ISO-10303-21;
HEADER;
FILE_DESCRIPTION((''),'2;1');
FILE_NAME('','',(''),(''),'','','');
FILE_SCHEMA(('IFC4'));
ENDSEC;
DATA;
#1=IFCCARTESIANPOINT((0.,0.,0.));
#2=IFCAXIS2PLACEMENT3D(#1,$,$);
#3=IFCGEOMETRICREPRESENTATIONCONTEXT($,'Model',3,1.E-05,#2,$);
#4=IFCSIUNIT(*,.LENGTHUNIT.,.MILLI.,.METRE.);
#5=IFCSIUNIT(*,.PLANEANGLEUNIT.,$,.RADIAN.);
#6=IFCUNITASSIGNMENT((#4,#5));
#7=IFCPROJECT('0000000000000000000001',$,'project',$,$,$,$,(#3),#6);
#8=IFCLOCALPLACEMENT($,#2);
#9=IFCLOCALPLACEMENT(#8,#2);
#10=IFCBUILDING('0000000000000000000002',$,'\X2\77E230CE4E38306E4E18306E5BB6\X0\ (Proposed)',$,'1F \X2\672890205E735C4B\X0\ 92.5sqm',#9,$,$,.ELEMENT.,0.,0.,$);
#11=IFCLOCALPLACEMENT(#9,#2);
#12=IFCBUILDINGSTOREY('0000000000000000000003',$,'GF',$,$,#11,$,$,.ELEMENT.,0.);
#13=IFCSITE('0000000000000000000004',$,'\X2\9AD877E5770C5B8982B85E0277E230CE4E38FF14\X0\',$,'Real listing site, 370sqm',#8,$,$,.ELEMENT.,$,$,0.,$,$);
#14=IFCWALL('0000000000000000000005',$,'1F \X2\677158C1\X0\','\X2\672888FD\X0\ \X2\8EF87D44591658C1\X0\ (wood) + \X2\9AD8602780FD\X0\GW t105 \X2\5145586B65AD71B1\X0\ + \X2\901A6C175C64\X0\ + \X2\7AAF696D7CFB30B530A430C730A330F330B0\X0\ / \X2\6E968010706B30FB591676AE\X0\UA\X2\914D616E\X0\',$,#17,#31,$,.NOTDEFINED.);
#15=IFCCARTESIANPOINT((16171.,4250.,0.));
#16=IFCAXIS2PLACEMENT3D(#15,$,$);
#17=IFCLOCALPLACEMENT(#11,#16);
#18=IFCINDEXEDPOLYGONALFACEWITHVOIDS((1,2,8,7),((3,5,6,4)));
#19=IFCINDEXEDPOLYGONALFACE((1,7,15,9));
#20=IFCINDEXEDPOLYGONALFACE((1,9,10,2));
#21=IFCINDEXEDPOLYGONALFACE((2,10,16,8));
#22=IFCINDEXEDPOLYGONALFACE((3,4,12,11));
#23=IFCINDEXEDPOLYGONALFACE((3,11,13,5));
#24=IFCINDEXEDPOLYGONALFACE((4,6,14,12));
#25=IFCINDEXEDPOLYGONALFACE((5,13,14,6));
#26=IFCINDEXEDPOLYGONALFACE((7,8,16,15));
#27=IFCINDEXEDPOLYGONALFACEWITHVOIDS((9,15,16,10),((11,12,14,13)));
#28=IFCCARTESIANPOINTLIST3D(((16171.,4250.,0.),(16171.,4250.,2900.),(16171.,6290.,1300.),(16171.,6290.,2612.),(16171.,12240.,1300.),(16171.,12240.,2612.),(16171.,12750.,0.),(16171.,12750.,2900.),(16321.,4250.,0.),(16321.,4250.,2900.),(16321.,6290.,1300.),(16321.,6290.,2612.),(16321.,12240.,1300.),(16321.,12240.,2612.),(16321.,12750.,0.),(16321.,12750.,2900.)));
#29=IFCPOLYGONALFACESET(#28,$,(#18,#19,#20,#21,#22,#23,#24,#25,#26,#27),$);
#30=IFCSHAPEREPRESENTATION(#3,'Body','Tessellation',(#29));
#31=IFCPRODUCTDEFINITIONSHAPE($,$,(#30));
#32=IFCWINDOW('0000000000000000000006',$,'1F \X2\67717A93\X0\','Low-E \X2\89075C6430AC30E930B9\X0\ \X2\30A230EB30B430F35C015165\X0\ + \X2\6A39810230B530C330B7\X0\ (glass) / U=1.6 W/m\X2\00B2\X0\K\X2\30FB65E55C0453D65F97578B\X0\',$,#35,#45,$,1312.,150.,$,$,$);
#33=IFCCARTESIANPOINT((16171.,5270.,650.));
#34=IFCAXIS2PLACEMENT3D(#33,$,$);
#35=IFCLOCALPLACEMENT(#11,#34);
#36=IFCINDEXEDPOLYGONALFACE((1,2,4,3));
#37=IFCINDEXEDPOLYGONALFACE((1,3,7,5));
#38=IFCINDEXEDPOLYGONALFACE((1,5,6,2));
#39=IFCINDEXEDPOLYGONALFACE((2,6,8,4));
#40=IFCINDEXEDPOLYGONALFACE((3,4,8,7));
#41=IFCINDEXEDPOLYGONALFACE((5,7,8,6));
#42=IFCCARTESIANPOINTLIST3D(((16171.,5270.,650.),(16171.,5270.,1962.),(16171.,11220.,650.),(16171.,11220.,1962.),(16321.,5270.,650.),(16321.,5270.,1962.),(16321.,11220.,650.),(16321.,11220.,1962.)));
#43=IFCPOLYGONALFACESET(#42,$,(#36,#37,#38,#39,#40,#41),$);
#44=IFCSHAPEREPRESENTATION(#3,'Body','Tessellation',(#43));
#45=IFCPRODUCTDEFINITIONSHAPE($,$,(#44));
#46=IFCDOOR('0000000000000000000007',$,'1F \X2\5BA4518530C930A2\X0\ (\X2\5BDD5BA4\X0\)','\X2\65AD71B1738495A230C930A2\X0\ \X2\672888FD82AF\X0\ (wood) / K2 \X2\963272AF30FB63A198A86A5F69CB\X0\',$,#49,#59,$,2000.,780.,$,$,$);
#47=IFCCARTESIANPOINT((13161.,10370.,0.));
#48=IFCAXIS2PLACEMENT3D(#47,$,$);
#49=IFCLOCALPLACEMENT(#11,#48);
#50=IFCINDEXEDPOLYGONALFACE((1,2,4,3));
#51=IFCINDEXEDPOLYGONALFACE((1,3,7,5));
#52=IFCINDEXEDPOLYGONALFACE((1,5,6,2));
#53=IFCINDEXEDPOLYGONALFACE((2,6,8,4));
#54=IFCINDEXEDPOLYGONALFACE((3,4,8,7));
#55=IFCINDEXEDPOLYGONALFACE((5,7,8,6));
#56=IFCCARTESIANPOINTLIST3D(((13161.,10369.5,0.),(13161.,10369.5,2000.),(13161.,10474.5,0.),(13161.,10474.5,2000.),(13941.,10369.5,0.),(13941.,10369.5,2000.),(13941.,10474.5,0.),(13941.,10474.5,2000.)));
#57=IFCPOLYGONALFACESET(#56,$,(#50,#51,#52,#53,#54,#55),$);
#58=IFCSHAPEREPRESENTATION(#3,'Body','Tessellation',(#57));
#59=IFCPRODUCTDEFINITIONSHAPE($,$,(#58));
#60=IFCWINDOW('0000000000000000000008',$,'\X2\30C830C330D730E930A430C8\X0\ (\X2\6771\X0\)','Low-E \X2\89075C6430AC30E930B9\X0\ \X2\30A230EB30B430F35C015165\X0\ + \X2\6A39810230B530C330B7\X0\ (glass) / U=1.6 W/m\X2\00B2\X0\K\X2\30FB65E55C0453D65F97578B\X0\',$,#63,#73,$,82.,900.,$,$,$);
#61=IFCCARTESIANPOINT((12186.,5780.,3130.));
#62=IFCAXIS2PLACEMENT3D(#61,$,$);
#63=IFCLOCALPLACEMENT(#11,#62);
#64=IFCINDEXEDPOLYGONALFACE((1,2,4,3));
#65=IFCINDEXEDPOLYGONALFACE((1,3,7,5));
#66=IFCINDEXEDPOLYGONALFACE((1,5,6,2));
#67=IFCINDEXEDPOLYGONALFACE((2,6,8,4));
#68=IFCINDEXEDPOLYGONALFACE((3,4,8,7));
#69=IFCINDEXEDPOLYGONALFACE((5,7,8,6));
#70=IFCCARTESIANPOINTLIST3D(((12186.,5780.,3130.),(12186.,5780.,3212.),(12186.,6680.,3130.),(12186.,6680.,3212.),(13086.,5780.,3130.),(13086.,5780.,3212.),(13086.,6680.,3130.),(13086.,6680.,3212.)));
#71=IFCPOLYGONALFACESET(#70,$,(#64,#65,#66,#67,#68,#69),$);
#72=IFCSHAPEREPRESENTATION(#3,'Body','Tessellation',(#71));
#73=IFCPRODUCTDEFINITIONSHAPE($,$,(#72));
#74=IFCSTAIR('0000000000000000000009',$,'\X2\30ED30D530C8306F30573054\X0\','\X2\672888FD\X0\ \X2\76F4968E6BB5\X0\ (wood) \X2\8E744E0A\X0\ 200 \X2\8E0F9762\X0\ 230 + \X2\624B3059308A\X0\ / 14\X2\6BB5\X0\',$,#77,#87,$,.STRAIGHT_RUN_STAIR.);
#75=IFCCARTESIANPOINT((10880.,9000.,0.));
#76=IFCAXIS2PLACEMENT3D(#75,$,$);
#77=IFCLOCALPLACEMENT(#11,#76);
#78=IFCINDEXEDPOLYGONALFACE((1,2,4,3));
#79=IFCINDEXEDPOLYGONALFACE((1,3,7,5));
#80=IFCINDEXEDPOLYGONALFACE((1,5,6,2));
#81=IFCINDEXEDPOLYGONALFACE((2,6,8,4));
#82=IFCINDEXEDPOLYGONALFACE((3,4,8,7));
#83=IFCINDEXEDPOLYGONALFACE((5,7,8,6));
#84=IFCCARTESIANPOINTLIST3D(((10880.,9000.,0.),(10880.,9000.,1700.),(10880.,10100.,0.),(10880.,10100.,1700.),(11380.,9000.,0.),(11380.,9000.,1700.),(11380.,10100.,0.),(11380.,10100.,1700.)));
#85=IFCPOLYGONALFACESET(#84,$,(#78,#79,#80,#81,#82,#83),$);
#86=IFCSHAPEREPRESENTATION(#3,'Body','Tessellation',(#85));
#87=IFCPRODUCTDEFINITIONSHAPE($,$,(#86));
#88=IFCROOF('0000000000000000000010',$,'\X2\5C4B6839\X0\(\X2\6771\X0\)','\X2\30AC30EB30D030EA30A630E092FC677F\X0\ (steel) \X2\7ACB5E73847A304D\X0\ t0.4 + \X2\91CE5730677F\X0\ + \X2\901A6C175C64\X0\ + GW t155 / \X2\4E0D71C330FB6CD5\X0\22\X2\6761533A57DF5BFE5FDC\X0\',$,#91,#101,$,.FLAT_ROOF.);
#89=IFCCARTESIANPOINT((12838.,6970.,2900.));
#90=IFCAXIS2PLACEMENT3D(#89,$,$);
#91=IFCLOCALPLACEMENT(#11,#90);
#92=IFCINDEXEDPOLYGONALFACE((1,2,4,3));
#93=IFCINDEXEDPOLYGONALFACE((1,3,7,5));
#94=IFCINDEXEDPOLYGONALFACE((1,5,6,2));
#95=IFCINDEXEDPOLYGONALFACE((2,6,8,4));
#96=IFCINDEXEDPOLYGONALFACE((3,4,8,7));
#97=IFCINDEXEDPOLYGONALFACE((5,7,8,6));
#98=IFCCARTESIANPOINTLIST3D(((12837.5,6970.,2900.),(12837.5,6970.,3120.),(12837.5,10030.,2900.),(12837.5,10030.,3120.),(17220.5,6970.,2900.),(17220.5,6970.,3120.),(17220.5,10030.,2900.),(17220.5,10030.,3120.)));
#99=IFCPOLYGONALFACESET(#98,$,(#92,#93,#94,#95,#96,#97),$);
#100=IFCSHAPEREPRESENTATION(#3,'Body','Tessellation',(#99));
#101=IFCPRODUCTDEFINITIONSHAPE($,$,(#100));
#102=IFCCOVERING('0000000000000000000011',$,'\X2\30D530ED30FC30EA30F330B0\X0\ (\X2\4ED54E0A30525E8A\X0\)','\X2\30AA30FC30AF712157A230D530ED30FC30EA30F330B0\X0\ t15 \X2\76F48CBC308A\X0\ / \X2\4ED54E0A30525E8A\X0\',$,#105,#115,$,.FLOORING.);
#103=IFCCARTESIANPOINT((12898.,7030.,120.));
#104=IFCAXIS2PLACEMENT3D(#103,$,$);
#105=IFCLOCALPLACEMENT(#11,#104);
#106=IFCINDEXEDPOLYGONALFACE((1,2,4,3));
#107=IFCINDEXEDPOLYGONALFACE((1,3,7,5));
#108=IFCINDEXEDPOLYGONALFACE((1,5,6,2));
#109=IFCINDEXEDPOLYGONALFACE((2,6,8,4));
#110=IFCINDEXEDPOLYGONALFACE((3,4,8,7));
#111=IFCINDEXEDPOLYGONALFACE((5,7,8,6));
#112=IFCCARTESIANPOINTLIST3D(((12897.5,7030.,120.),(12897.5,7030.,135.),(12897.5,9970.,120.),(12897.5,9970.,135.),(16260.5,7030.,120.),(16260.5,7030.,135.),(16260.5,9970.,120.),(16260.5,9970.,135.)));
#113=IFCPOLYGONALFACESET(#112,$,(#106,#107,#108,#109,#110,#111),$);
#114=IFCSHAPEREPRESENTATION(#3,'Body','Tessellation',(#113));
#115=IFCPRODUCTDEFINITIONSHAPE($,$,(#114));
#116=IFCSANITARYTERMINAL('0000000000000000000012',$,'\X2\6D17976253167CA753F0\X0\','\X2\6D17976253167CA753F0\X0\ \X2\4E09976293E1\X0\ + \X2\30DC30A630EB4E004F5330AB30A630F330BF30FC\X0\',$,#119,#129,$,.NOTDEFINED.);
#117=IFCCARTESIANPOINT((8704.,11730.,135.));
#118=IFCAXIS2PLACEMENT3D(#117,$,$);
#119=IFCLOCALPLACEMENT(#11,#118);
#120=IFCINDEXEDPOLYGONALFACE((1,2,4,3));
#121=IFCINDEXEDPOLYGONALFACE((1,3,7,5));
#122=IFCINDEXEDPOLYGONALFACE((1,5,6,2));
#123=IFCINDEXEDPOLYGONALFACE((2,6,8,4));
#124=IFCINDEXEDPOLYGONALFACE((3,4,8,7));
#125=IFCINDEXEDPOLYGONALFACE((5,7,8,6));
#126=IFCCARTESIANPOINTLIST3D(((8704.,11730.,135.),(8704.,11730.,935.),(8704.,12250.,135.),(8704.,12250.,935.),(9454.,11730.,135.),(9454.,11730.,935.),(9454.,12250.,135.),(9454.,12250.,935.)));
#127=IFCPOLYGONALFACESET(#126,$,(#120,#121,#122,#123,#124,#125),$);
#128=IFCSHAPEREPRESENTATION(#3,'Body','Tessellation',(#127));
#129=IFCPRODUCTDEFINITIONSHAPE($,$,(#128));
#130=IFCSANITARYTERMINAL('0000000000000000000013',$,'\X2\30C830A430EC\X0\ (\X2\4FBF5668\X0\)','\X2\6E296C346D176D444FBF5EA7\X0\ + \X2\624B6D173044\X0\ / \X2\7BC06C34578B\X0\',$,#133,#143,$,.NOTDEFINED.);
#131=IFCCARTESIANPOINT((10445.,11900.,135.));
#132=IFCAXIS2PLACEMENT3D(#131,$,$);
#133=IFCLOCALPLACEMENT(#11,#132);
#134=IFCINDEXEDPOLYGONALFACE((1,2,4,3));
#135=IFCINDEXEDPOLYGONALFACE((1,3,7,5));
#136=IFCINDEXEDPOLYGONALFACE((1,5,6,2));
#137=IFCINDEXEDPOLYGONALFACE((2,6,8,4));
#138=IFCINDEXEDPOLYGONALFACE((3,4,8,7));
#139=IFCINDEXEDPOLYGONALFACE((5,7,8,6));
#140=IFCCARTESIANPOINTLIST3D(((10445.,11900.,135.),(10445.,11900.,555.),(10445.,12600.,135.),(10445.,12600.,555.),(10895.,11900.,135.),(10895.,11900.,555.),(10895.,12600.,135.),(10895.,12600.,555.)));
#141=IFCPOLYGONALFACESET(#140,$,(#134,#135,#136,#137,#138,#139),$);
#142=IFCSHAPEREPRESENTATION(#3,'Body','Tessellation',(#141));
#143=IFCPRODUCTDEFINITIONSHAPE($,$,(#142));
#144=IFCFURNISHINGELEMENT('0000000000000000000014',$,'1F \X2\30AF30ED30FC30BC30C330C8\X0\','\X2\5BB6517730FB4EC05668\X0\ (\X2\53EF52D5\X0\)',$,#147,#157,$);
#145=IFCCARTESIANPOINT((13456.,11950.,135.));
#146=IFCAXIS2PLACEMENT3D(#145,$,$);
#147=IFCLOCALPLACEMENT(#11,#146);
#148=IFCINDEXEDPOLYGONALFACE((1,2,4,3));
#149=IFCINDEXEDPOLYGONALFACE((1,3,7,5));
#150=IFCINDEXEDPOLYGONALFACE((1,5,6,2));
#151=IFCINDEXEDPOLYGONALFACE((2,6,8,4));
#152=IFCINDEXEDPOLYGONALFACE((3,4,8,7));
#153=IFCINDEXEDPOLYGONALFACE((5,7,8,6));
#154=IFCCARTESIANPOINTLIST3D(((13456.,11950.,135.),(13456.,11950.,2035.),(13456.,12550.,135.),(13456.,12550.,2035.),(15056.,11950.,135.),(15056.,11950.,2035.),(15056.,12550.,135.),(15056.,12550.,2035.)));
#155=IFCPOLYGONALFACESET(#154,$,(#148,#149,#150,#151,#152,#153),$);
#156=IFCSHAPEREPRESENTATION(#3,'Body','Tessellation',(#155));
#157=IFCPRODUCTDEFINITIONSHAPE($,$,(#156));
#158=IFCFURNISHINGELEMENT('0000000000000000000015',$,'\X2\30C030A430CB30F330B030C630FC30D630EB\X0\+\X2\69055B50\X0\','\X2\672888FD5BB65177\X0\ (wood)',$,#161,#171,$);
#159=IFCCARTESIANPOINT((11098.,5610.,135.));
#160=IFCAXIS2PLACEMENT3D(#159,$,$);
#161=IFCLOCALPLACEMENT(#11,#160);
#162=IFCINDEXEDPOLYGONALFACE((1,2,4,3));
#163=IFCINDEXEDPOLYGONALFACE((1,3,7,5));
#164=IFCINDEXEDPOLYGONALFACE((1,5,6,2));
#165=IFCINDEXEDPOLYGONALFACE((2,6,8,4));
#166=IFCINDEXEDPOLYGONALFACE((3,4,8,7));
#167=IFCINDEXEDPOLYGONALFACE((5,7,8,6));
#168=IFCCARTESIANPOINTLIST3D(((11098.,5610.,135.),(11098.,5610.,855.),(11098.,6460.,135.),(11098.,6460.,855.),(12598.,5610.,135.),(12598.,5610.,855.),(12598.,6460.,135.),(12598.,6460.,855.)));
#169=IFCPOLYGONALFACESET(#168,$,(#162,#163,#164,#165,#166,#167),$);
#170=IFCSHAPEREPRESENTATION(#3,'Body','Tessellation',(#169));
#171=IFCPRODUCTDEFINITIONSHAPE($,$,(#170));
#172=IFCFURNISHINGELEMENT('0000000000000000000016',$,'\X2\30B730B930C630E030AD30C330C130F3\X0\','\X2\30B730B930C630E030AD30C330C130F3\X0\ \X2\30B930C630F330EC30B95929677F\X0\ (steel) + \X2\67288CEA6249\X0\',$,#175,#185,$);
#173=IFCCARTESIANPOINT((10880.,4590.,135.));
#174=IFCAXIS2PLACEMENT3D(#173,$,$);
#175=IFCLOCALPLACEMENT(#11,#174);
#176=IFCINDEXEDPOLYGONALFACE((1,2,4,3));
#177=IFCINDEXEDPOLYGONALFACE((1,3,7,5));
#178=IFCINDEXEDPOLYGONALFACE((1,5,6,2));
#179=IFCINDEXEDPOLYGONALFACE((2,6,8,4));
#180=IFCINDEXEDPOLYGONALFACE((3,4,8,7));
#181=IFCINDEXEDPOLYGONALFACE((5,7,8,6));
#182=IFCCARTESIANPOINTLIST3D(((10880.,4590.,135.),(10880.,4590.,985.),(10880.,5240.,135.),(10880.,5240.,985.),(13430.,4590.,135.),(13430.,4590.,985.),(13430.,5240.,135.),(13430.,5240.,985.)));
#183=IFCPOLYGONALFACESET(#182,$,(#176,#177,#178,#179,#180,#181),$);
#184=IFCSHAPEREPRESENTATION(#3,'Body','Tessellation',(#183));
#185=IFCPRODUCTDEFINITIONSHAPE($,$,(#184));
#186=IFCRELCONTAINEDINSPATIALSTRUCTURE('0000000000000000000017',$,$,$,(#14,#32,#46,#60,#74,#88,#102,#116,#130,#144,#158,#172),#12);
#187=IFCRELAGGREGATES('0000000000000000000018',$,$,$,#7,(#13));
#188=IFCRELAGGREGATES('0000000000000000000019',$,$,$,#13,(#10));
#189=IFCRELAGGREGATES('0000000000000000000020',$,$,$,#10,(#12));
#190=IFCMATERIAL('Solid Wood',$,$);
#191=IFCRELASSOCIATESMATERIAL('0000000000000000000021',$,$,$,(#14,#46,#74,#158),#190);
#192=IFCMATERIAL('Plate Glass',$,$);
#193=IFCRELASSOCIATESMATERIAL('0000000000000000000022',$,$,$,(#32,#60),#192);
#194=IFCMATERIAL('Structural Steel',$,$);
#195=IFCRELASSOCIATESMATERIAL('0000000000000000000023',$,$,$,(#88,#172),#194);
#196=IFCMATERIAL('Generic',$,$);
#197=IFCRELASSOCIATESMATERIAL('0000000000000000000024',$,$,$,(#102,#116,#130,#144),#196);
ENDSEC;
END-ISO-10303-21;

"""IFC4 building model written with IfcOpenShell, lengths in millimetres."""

from ifc_helpers import new_model, si_unit, frame, frame_2d, origin, place, context, project, spatial, rectangle, extrude, material, element, fill, save


model = new_model("IFC4")

# Units and contexts
model_context = context("Model", 3, precision=1e-05, world=origin())
ifc_project = project(units=[si_unit("LENGTHUNIT", "METRE", prefix="MILLI"), si_unit("PLANEANGLEUNIT", "RADIAN")], contexts=[model_context])

# Site, building, storey
site_placement = place(None, origin())
site = spatial("IfcSite", under=ifc_project, at=site_placement, Name="高知県安芸市矢ノ丸４", ObjectType="Real listing site, 370sqm", CompositionType="ELEMENT", RefElevation=0.0)
building_placement = place(site_placement, origin())
building = spatial("IfcBuilding", under=site, at=building_placement, Name="矢ノ丸の丘の家 (Proposed)", ObjectType="1F 木造平屋 92.5sqm", CompositionType="ELEMENT", ElevationOfRefHeight=0.0, ElevationOfTerrain=0.0)
storey_placement = place(building_placement, origin())
storey = spatial("IfcBuildingStorey", under=building, at=storey_placement, Name="GF", CompositionType="ELEMENT", Elevation=0.0)

# Shared definitions
ifc_material_1 = material(Name="Solid Wood")

# Wall, opening, window
wall_1_placement = place(storey_placement, frame((16171.0, 4250.0, 0.0)))
wall_1 = element("IfcWall", 1, at=wall_1_placement, inside=storey, material=ifc_material_1, Name="1F 東壁", Description="木製 軸組外壁 (wood) + 高性能GW t105 充填断熱 + 通気層 + 窯業系サイディング / 準耐火・外皮UA配慮", PredefinedType="NOTDEFINED", context=model_context, shape_type="SweptSolid", body=[
    extrude(rectangle(XDim=150.0, YDim=8500.0, at=frame_2d((75.0, 4250.0))), frame((16171.0, 4250.0, 0.0)), (0.0, 0.0, 1.0), 2900.0),
])
opening_1_placement = place(storey_placement, frame((16171.0, 5270.0, 650.0)))
opening_1 = element("IfcOpeningElement", 2, at=opening_1_placement, cuts=wall_1, PredefinedType="NOTDEFINED", context=model_context, shape_type="SweptSolid", body=[
    extrude(rectangle(XDim=150.0, YDim=5950.0, at=frame_2d((75.0, 2975.0))), frame((16171.0, 5270.0, 650.0)), (0.0, 0.0, 1.0), 1312.0),
])
ifc_material_2 = material(Name="Plate Glass")
window_1_placement = place(storey_placement, frame((16171.0, 5270.0, 650.0)))
window_1 = element("IfcWindow", 3, at=window_1_placement, inside=storey, material=ifc_material_2, Name="1F 東窓", Description="Low-E 複層ガラス アルゴン封入 + 樹脂サッシ (glass) / U=1.6 W/m²K・日射取得型", OverallHeight=1312.0, OverallWidth=150.0, context=model_context, shape_type="SweptSolid", body=[
    extrude(rectangle(XDim=150.0, YDim=5950.0, at=frame_2d((75.0, 2975.0))), frame((16171.0, 5270.0, 650.0)), (0.0, 0.0, 1.0), 1312.0),
])
fill(opening_1, window_1)

# Door
door_placement = place(storey_placement, frame((13161.0, 10370.0, 0.0)))
element("IfcDoor", 4, at=door_placement, inside=storey, material=ifc_material_1, Name="1F 室内ドア (寝室)", Description="断熱玄関ドア 木製芯 (wood) / K2 防犯・採風機構", OverallHeight=2000.0, OverallWidth=780.0, context=model_context, shape_type="SweptSolid", body=[
    extrude(rectangle(XDim=780.0, YDim=105.0, at=frame_2d((390.0, 52.0))), frame((13161.0, 10370.0, 0.0)), (0.0, 0.0, 1.0), 2000.0),
])

# Window
window_2_placement = place(storey_placement, frame((12186.0, 5780.0, 3130.0)))
element("IfcWindow", 5, at=window_2_placement, inside=storey, material=ifc_material_2, Name="トップライト (東)", Description="Low-E 複層ガラス アルゴン封入 + 樹脂サッシ (glass) / U=1.6 W/m²K・日射取得型", OverallHeight=82.0, OverallWidth=900.0, context=model_context, shape_type="SweptSolid", body=[
    extrude(rectangle(XDim=900.0, YDim=900.0, at=frame_2d((450.0, 450.0))), frame((12186.0, 5780.0, 3130.0)), (0.0, 0.0, 1.0), 82.0),
])

# Stair
stair_placement = place(storey_placement, frame((10880.0, 9000.0, 0.0)))
element("IfcStair", 6, at=stair_placement, inside=storey, material=ifc_material_1, Name="ロフトはしご", Description="木製 直階段 (wood) 蹴上 200 踏面 230 + 手すり / 14段", PredefinedType="STRAIGHT_RUN_STAIR", context=model_context, shape_type="SweptSolid", body=[
    extrude(rectangle(XDim=500.0, YDim=1100.0, at=frame_2d((250.0, 550.0))), frame((10880.0, 9000.0, 0.0)), (0.0, 0.0, 1.0), 1700.0),
])

# Roof
ifc_material_3 = material(Name="Structural Steel")
roof_placement = place(storey_placement, frame((12838.0, 6970.0, 2900.0)))
element("IfcRoof", 7, at=roof_placement, inside=storey, material=ifc_material_3, Name="屋根(東)", Description="ガルバリウム鋼板 (steel) 立平葺き t0.4 + 野地板 + 通気層 + GW t155 / 不燃・法22条区域対応", PredefinedType="FLAT_ROOF", context=model_context, shape_type="SweptSolid", body=[
    extrude(rectangle(XDim=4383.0, YDim=3060.0, at=frame_2d((2191.0, 1530.0))), frame((12838.0, 6970.0, 2900.0)), (0.0, 0.0, 1.0), 220.0),
])

# Covering
ifc_material_4 = material(Name="Generic")
covering_placement = place(storey_placement, frame((12898.0, 7030.0, 120.0)))
element("IfcCovering", 8, at=covering_placement, inside=storey, material=ifc_material_4, Name="フローリング (仕上げ床)", Description="オーク無垢フローリング t15 直貼り / 仕上げ床", PredefinedType="FLOORING", context=model_context, shape_type="SweptSolid", body=[
    extrude(rectangle(XDim=3363.0, YDim=2940.0, at=frame_2d((1681.0, 1470.0))), frame((12898.0, 7030.0, 120.0)), (0.0, 0.0, 1.0), 15.0),
])

# Sanitary terminals
sanitary_terminal_1_placement = place(storey_placement, frame((8704.0, 11730.0, 135.0)))
element("IfcSanitaryTerminal", 9, at=sanitary_terminal_1_placement, inside=storey, material=ifc_material_4, Name="洗面化粧台", Description="洗面化粧台 三面鏡 + ボウル一体カウンター", PredefinedType="NOTDEFINED", context=model_context, shape_type="SweptSolid", body=[
    extrude(rectangle(XDim=750.0, YDim=520.0, at=frame_2d((375.0, 260.0))), frame((8704.0, 11730.0, 135.0)), (0.0, 0.0, 1.0), 800.0),
])
sanitary_terminal_2_placement = place(storey_placement, frame((10445.0, 11900.0, 135.0)))
element("IfcSanitaryTerminal", 10, at=sanitary_terminal_2_placement, inside=storey, material=ifc_material_4, Name="トイレ (便器)", Description="温水洗浄便座 + 手洗い / 節水型", PredefinedType="NOTDEFINED", context=model_context, shape_type="SweptSolid", body=[
    extrude(rectangle(XDim=450.0, YDim=700.0, at=frame_2d((225.0, 350.0))), frame((10445.0, 11900.0, 135.0)), (0.0, 0.0, 1.0), 420.0),
])

# Furnishing elements
furnishing_1_placement = place(storey_placement, frame((13456.0, 11950.0, 135.0)))
element("IfcFurnishingElement", 11, at=furnishing_1_placement, inside=storey, material=ifc_material_4, Name="1F クローゼット", Description="家具・什器 (可動)", context=model_context, shape_type="SweptSolid", body=[
    extrude(rectangle(XDim=1600.0, YDim=600.0, at=frame_2d((800.0, 300.0))), frame((13456.0, 11950.0, 135.0)), (0.0, 0.0, 1.0), 1900.0),
])
furnishing_2_placement = place(storey_placement, frame((11098.0, 5610.0, 135.0)))
element("IfcFurnishingElement", 12, at=furnishing_2_placement, inside=storey, material=ifc_material_1, Name="ダイニングテーブル+椅子", Description="木製家具 (wood)", context=model_context, shape_type="SweptSolid", body=[
    extrude(rectangle(XDim=1500.0, YDim=850.0, at=frame_2d((750.0, 425.0))), frame((11098.0, 5610.0, 135.0)), (0.0, 0.0, 1.0), 720.0),
])
furnishing_3_placement = place(storey_placement, frame((10880.0, 4590.0, 135.0)))
element("IfcFurnishingElement", 13, at=furnishing_3_placement, inside=storey, material=ifc_material_3, Name="システムキッチン", Description="システムキッチン ステンレス天板 (steel) + 木質扉", context=model_context, shape_type="SweptSolid", body=[
    extrude(rectangle(XDim=2550.0, YDim=650.0, at=frame_2d((1275.0, 325.0))), frame((10880.0, 4590.0, 135.0)), (0.0, 0.0, 1.0), 850.0),
])

save(model, "model.ifc")
